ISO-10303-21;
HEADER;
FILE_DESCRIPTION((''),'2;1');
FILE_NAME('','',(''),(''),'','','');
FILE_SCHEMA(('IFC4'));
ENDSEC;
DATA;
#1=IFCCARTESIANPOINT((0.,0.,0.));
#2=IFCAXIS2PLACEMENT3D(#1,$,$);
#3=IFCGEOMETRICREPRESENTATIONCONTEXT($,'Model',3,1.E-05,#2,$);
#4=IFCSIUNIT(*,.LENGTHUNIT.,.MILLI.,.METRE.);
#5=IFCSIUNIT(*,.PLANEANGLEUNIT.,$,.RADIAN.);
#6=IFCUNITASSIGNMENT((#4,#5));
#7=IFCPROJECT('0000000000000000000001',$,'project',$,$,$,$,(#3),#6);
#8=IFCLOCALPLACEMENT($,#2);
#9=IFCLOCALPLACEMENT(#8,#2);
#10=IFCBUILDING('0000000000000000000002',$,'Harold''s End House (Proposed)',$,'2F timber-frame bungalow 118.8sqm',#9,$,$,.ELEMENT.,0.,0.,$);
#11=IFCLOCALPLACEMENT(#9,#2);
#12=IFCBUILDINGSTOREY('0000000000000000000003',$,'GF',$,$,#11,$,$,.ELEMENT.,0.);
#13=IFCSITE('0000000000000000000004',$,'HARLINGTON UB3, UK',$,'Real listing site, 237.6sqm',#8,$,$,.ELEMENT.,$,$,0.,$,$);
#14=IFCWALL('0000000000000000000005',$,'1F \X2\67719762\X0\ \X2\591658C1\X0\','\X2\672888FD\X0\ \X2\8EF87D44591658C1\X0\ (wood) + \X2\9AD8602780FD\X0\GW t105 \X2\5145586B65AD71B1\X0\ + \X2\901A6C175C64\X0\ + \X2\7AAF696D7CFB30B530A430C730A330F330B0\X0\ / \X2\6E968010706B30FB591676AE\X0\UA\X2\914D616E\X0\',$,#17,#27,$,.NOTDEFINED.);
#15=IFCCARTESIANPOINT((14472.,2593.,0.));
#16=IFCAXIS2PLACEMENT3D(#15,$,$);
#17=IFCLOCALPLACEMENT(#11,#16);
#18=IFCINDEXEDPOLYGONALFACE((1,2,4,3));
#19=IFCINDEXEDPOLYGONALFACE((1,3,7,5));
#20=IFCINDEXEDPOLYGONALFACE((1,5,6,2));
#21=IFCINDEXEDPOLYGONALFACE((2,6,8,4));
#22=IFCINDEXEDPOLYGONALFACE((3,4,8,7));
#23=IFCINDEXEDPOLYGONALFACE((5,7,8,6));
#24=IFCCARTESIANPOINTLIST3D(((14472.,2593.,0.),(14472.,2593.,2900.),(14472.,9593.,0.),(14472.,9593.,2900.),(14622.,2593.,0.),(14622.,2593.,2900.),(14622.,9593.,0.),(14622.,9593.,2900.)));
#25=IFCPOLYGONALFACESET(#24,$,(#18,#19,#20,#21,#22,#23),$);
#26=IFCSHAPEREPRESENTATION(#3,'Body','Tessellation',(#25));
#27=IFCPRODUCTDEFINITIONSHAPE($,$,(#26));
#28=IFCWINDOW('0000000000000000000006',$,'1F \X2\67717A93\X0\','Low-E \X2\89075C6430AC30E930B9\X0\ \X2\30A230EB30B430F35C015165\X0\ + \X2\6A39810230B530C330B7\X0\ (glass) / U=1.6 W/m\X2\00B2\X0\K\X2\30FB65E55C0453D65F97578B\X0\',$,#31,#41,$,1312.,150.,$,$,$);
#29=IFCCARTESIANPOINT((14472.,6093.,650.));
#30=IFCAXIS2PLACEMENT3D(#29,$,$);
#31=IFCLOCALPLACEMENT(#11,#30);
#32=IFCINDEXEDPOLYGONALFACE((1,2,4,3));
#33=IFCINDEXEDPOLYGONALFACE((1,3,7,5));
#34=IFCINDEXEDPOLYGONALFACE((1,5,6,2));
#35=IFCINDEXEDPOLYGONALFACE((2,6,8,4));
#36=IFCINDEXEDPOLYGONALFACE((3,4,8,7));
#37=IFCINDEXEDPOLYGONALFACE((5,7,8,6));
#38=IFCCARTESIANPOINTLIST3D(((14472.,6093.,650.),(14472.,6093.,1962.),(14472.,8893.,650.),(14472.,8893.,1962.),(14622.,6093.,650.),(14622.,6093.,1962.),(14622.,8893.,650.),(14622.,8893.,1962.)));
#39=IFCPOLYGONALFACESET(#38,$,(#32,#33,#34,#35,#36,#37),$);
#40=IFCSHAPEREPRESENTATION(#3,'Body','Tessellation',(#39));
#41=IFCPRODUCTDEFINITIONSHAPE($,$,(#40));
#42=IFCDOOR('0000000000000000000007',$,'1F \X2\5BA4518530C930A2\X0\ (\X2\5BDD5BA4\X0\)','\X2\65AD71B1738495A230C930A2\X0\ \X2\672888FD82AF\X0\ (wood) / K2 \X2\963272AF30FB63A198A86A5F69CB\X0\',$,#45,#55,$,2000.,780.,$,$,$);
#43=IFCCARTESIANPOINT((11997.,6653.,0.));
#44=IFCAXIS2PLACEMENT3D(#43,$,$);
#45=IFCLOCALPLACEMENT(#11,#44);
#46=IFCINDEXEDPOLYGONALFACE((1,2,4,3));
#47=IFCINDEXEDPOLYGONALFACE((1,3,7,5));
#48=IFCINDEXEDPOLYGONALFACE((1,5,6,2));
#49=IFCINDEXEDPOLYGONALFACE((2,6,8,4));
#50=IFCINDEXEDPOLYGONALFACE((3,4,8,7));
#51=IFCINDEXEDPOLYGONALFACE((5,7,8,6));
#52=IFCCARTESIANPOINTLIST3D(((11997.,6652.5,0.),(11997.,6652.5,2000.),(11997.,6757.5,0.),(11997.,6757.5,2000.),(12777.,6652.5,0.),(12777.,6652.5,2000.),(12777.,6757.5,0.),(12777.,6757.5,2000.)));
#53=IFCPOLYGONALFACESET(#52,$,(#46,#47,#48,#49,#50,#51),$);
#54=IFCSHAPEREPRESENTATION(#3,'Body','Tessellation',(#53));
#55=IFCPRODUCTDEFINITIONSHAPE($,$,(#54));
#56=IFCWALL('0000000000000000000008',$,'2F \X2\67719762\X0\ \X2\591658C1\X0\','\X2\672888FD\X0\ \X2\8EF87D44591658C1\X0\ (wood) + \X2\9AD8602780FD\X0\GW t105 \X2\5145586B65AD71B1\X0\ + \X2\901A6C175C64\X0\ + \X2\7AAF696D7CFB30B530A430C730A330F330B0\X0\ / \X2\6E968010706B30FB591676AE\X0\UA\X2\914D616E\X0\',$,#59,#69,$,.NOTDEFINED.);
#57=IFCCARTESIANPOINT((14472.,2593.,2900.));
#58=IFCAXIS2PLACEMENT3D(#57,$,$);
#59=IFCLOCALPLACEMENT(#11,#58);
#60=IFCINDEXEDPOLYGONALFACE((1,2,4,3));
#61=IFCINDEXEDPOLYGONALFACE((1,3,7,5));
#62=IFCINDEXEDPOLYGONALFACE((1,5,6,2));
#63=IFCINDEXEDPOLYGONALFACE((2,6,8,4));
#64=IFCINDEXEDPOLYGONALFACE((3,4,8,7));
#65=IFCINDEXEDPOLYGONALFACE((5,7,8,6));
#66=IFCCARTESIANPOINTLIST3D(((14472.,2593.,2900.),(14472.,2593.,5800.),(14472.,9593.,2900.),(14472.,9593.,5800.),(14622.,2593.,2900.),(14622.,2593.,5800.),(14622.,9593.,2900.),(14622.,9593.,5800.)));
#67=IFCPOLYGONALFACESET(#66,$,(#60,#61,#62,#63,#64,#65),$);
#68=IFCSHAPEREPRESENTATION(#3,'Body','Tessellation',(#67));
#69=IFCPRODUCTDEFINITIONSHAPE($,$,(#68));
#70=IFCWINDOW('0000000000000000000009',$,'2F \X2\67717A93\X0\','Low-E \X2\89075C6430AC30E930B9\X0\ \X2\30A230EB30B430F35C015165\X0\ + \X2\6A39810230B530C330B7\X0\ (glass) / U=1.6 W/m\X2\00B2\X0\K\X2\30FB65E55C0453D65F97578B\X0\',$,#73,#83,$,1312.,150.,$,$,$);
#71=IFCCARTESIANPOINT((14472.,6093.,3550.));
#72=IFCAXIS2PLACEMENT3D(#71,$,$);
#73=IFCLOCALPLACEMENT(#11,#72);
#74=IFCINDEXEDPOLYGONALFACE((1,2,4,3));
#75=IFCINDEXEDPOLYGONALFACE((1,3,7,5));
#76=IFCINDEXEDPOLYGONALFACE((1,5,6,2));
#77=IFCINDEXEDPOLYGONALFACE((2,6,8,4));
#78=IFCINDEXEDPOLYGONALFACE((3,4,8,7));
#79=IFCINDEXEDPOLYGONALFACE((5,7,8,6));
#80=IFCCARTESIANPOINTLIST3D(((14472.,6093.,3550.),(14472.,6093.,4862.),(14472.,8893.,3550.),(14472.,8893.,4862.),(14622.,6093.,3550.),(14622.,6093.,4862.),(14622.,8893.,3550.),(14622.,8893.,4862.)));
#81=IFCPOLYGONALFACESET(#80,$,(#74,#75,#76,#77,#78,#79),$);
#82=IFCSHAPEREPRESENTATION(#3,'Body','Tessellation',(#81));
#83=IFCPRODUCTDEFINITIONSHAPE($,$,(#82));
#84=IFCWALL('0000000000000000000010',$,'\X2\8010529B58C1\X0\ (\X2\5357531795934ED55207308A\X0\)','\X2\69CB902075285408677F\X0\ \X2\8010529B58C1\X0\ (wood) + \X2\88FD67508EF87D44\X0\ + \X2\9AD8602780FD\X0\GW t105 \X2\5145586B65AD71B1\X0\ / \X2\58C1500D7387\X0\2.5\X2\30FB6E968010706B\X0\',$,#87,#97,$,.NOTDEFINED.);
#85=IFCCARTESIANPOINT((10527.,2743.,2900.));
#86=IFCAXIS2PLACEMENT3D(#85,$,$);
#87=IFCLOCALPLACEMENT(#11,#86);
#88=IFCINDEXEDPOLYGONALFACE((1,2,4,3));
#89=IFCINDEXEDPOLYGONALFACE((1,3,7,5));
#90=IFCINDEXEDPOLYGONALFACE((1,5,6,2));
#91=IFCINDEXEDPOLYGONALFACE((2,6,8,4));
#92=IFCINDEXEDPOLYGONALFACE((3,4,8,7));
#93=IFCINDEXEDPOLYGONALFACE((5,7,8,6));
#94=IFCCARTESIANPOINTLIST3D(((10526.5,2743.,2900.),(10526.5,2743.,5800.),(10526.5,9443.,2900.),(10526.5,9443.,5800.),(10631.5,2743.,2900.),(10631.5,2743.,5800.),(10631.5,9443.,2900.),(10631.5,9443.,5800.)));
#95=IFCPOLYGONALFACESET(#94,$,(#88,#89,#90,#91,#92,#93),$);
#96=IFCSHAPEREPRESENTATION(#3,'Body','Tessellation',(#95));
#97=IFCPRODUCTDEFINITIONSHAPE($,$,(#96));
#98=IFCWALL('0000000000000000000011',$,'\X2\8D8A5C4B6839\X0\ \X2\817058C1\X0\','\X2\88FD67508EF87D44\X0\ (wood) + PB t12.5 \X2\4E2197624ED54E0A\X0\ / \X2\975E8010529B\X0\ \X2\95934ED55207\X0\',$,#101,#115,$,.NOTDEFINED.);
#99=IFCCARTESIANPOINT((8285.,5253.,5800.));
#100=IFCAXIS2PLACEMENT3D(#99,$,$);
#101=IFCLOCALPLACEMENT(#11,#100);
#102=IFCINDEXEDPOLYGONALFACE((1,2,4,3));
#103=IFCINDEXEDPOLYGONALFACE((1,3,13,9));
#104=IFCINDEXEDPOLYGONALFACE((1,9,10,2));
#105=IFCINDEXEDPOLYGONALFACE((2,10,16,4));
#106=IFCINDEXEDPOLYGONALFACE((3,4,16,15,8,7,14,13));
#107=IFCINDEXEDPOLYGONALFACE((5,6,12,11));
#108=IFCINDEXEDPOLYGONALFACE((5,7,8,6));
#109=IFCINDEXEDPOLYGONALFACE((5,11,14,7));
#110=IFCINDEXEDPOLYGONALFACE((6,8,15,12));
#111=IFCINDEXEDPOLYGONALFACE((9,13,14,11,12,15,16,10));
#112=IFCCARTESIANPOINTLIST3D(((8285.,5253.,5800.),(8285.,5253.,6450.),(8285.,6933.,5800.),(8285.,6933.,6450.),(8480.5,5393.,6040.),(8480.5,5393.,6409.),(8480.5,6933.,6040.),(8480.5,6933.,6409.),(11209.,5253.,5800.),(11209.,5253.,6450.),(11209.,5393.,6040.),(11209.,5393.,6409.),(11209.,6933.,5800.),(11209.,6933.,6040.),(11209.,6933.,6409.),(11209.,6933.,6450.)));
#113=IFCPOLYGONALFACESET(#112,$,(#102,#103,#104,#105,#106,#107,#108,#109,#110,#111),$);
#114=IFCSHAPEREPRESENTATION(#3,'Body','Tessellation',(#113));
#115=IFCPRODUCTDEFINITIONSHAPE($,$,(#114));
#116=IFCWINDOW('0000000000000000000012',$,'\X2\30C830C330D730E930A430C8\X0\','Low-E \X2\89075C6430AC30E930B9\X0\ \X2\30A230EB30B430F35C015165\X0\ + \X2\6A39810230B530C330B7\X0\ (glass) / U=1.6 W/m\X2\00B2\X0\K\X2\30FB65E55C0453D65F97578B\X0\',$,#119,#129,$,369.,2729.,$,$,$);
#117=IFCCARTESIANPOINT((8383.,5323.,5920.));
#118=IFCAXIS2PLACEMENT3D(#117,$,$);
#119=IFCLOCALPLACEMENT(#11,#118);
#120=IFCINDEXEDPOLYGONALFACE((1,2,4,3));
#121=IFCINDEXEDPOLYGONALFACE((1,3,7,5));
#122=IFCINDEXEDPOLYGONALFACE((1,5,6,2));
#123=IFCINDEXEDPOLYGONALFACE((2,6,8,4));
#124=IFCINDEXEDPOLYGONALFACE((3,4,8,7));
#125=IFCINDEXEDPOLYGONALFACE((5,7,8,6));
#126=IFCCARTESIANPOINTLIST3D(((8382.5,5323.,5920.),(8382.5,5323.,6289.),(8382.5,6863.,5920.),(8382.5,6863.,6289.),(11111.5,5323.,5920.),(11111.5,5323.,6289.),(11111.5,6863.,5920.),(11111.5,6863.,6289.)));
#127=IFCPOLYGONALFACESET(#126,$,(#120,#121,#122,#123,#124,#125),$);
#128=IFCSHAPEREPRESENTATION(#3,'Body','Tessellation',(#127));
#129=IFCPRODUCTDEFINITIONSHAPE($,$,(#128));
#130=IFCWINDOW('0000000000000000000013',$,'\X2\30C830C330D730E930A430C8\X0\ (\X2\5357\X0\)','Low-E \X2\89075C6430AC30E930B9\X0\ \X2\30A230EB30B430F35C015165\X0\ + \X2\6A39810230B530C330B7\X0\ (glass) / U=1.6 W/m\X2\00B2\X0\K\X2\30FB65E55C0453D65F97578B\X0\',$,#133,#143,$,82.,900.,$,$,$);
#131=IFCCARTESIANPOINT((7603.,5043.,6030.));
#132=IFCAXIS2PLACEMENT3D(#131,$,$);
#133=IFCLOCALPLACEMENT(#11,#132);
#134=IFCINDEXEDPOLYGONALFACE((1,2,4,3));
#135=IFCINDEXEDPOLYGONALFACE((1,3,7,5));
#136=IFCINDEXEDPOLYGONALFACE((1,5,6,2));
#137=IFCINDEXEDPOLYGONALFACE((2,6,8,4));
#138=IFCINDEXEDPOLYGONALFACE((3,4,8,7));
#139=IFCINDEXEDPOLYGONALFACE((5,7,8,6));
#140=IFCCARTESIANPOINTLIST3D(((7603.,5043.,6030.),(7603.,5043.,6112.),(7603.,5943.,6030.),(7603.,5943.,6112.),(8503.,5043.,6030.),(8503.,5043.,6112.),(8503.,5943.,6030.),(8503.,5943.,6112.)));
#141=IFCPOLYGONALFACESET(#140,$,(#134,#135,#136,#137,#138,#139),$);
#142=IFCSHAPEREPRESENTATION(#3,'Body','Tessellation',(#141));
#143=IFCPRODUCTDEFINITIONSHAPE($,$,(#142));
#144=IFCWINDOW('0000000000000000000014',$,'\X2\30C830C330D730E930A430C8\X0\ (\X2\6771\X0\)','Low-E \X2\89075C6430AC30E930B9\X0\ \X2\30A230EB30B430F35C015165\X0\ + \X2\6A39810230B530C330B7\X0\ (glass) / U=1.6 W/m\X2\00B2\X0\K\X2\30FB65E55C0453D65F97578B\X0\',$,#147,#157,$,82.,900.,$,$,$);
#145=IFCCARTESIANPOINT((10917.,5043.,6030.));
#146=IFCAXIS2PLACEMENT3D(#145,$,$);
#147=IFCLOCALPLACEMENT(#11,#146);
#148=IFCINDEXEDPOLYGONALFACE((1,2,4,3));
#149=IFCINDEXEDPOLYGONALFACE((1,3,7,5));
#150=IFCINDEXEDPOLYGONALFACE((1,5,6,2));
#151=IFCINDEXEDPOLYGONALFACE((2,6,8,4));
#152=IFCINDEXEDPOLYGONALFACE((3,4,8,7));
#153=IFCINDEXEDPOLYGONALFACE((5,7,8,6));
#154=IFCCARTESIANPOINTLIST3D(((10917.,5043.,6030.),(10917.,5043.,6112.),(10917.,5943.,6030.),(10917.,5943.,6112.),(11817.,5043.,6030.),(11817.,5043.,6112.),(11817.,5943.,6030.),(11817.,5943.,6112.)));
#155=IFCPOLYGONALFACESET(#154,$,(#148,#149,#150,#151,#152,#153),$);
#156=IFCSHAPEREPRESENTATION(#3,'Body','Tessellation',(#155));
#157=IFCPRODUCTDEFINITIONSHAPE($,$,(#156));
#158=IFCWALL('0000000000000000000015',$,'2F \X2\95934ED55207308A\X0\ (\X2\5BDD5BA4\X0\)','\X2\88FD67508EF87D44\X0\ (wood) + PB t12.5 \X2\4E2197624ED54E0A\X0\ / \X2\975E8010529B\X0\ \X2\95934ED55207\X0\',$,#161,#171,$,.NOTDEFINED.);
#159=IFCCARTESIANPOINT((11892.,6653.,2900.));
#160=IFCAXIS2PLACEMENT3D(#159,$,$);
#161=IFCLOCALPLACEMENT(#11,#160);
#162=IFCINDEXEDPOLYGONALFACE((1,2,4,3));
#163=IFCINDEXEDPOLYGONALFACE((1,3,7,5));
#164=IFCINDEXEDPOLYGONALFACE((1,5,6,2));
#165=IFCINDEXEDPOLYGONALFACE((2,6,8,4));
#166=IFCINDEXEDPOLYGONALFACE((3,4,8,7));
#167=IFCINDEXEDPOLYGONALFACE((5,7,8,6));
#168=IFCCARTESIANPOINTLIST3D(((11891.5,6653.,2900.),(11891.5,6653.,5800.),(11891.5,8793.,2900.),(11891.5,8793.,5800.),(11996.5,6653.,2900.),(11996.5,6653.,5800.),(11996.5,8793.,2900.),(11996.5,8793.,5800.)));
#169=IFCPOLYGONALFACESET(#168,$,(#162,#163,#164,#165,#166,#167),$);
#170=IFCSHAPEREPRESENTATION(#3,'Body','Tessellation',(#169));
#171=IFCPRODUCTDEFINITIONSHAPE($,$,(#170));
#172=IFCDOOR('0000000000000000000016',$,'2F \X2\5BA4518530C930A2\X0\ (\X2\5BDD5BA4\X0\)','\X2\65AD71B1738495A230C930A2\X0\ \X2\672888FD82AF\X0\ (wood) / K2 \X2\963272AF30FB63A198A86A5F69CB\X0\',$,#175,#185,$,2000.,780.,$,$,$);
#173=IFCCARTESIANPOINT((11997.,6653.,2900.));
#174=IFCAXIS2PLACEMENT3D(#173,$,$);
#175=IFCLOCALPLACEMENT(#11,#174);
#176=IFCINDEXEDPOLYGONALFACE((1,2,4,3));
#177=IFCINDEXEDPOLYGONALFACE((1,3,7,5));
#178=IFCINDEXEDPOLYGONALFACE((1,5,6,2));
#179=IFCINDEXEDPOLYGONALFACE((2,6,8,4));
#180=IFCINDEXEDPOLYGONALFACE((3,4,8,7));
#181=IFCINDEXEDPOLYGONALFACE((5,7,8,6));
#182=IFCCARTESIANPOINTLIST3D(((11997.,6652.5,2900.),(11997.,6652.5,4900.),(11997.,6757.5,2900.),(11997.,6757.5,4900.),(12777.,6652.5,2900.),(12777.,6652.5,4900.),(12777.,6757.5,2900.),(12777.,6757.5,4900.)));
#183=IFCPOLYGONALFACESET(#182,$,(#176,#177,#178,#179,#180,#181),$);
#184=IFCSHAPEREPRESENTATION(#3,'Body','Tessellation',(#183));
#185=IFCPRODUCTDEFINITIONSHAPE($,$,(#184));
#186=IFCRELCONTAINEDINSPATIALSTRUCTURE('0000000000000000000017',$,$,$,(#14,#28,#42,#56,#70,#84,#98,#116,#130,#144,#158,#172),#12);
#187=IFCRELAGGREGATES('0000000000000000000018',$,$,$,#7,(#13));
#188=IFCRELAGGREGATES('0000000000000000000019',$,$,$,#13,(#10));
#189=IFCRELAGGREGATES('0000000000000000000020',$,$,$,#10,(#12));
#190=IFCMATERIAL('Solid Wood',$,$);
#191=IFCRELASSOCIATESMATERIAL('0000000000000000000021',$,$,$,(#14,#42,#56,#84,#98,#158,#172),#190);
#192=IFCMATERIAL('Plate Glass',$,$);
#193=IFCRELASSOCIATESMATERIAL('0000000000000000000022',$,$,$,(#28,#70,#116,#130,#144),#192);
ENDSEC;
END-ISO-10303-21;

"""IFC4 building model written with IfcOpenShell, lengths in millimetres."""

from ifc_helpers import new_model, si_unit, frame, frame_2d, origin, place, context, project, spatial, rectangle, extrude, material, element, fill, save


model = new_model("IFC4")

# Units and contexts
model_context = context("Model", 3, precision=1e-05, world=origin())
ifc_project = project(units=[si_unit("LENGTHUNIT", "METRE", prefix="MILLI"), si_unit("PLANEANGLEUNIT", "RADIAN")], contexts=[model_context])

# Site, building, storey
site_placement = place(None, origin())
site = spatial("IfcSite", under=ifc_project, at=site_placement, Name="HARLINGTON UB3, UK", ObjectType="Real listing site, 237.6sqm", CompositionType="ELEMENT", RefElevation=0.0)
building_placement = place(site_placement, origin())
building = spatial("IfcBuilding", under=site, at=building_placement, Name="Harold's End House (Proposed)", ObjectType="2F timber-frame bungalow 118.8sqm", CompositionType="ELEMENT", ElevationOfRefHeight=0.0, ElevationOfTerrain=0.0)
storey_placement = place(building_placement, origin())
storey = spatial("IfcBuildingStorey", under=building, at=storey_placement, Name="GF", CompositionType="ELEMENT", Elevation=0.0)

# Wall, opening, window
ifc_material_1 = material(Name="Solid Wood")
wall_1_placement = place(storey_placement, frame((14472.0, 2593.0, 0.0)))
wall_1 = element("IfcWall", 1, at=wall_1_placement, inside=storey, material=ifc_material_1, Name="1F 東面 外壁", Description="木製 軸組外壁 (wood) + 高性能GW t105 充填断熱 + 通気層 + 窯業系サイディング / 準耐火・外皮UA配慮", PredefinedType="NOTDEFINED", context=model_context, shape_type="SweptSolid", body=[
    extrude(rectangle(XDim=150.0, YDim=7000.0, at=frame_2d((75.0, 3500.0))), frame((14472.0, 2593.0, 0.0)), (0.0, 0.0, 1.0), 2900.0),
])
opening_1_placement = place(storey_placement, frame((14472.0, 6093.0, 650.0)))
opening_1 = element("IfcOpeningElement", 2, at=opening_1_placement, cuts=wall_1, PredefinedType="NOTDEFINED", context=model_context, shape_type="SweptSolid", body=[
    extrude(rectangle(XDim=150.0, YDim=2800.0, at=frame_2d((75.0, 1400.0))), frame((14472.0, 6093.0, 650.0)), (0.0, 0.0, 1.0), 1312.0),
])
ifc_material_2 = material(Name="Plate Glass")
window_1_placement = place(storey_placement, frame((14472.0, 6093.0, 650.0)))
window_1 = element("IfcWindow", 3, at=window_1_placement, inside=storey, material=ifc_material_2, Name="1F 東窓", Description="Low-E 複層ガラス アルゴン封入 + 樹脂サッシ (glass) / U=1.6 W/m²K・日射取得型", OverallHeight=1312.0, OverallWidth=150.0, context=model_context, shape_type="SweptSolid", body=[
    extrude(rectangle(XDim=150.0, YDim=2800.0, at=frame_2d((75.0, 1400.0))), frame((14472.0, 6093.0, 650.0)), (0.0, 0.0, 1.0), 1312.0),
])
fill(opening_1, window_1)

# Door
door_1_placement = place(storey_placement, frame((11997.0, 6653.0, 0.0)))
element("IfcDoor", 4, at=door_1_placement, inside=storey, material=ifc_material_1, Name="1F 室内ドア (寝室)", Description="断熱玄関ドア 木製芯 (wood) / K2 防犯・採風機構", OverallHeight=2000.0, OverallWidth=780.0, context=model_context, shape_type="SweptSolid", body=[
    extrude(rectangle(XDim=780.0, YDim=105.0, at=frame_2d((390.0, 52.0))), frame((11997.0, 6653.0, 0.0)), (0.0, 0.0, 1.0), 2000.0),
])

# Wall, opening, window
wall_2_placement = place(storey_placement, frame((14472.0, 2593.0, 2900.0)))
wall_2 = element("IfcWall", 5, at=wall_2_placement, inside=storey, material=ifc_material_1, Name="2F 東面 外壁", Description="木製 軸組外壁 (wood) + 高性能GW t105 充填断熱 + 通気層 + 窯業系サイディング / 準耐火・外皮UA配慮", PredefinedType="NOTDEFINED", context=model_context, shape_type="SweptSolid", body=[
    extrude(rectangle(XDim=150.0, YDim=7000.0, at=frame_2d((75.0, 3500.0))), frame((14472.0, 2593.0, 2900.0)), (0.0, 0.0, 1.0), 2900.0),
])
opening_2_placement = place(storey_placement, frame((14472.0, 6093.0, 3550.0)))
opening_2 = element("IfcOpeningElement", 6, at=opening_2_placement, cuts=wall_2, PredefinedType="NOTDEFINED", context=model_context, shape_type="SweptSolid", body=[
    extrude(rectangle(XDim=150.0, YDim=2800.0, at=frame_2d((75.0, 1400.0))), frame((14472.0, 6093.0, 3550.0)), (0.0, 0.0, 1.0), 1312.0),
])
window_2_placement = place(storey_placement, frame((14472.0, 6093.0, 3550.0)))
window_2 = element("IfcWindow", 7, at=window_2_placement, inside=storey, material=ifc_material_2, Name="2F 東窓", Description="Low-E 複層ガラス アルゴン封入 + 樹脂サッシ (glass) / U=1.6 W/m²K・日射取得型", OverallHeight=1312.0, OverallWidth=150.0, context=model_context, shape_type="SweptSolid", body=[
    extrude(rectangle(XDim=150.0, YDim=2800.0, at=frame_2d((75.0, 1400.0))), frame((14472.0, 6093.0, 3550.0)), (0.0, 0.0, 1.0), 1312.0),
])
fill(opening_2, window_2)

# Wall
wall_3_placement = place(storey_placement, frame((10527.0, 2743.0, 2900.0)))
element("IfcWall", 8, at=wall_3_placement, inside=storey, material=ifc_material_1, Name="耐力壁 (南北間仕切り)", Description="構造用合板 耐力壁 (wood) + 製材軸組 + 高性能GW t105 充填断熱 / 壁倍率2.5・準耐火", PredefinedType="NOTDEFINED", context=model_context, shape_type="SweptSolid", body=[
    extrude(rectangle(XDim=105.0, YDim=6700.0, at=frame_2d((52.0, 3350.0))), frame((10527.0, 2743.0, 2900.0)), (0.0, 0.0, 1.0), 2900.0),
])

# Wall, openings, windows
wall_4_placement = place(storey_placement, frame((8285.0, 5253.0, 5800.0)))
wall_4 = element("IfcWall", 9, at=wall_4_placement, inside=storey, material=ifc_material_1, Name="越屋根 腰壁", Description="製材軸組 (wood) + PB t12.5 両面仕上 / 非耐力 間仕切", PredefinedType="NOTDEFINED", context=model_context, shape_type="SweptSolid", body=[
    extrude(rectangle(XDim=2924.0, YDim=1680.0, at=frame_2d((1462.0, 840.0))), frame((8285.0, 5253.0, 5800.0)), (0.0, 0.0, 1.0), 650.0),
])
opening_3_placement = place(storey_placement, frame((8383.0, 5323.0, 5920.0)))
opening_3 = element("IfcOpeningElement", 10, at=opening_3_placement, cuts=wall_4, PredefinedType="NOTDEFINED", context=model_context, shape_type="SweptSolid", body=[
    extrude(rectangle(XDim=2729.0, YDim=1540.0, at=frame_2d((1364.0, 770.0))), frame((8383.0, 5323.0, 5920.0)), (0.0, 0.0, 1.0), 369.0),
])
opening_4_placement = place(storey_placement, frame((7603.0, 5043.0, 6030.0)))
opening_4 = element("IfcOpeningElement", 11, at=opening_4_placement, cuts=wall_4, PredefinedType="NOTDEFINED", context=model_context, shape_type="SweptSolid", body=[
    extrude(rectangle(XDim=900.0, YDim=900.0, at=frame_2d((450.0, 450.0))), frame((7603.0, 5043.0, 6030.0)), (0.0, 0.0, 1.0), 82.0),
])
opening_5_placement = place(storey_placement, frame((10917.0, 5043.0, 6030.0)))
opening_5 = element("IfcOpeningElement", 12, at=opening_5_placement, cuts=wall_4, PredefinedType="NOTDEFINED", context=model_context, shape_type="SweptSolid", body=[
    extrude(rectangle(XDim=900.0, YDim=900.0, at=frame_2d((450.0, 450.0))), frame((10917.0, 5043.0, 6030.0)), (0.0, 0.0, 1.0), 82.0),
])
window_3_placement = place(storey_placement, frame((8383.0, 5323.0, 5920.0)))
window_3 = element("IfcWindow", 13, at=window_3_placement, inside=storey, material=ifc_material_2, Name="トップライト", Description="Low-E 複層ガラス アルゴン封入 + 樹脂サッシ (glass) / U=1.6 W/m²K・日射取得型", OverallHeight=369.0, OverallWidth=2729.0, context=model_context, shape_type="SweptSolid", body=[
    extrude(rectangle(XDim=2729.0, YDim=1540.0, at=frame_2d((1364.0, 770.0))), frame((8383.0, 5323.0, 5920.0)), (0.0, 0.0, 1.0), 369.0),
])
fill(opening_3, window_3)
window_4_placement = place(storey_placement, frame((7603.0, 5043.0, 6030.0)))
window_4 = element("IfcWindow", 14, at=window_4_placement, inside=storey, material=ifc_material_2, Name="トップライト (南)", Description="Low-E 複層ガラス アルゴン封入 + 樹脂サッシ (glass) / U=1.6 W/m²K・日射取得型", OverallHeight=82.0, OverallWidth=900.0, context=model_context, shape_type="SweptSolid", body=[
    extrude(rectangle(XDim=900.0, YDim=900.0, at=frame_2d((450.0, 450.0))), frame((7603.0, 5043.0, 6030.0)), (0.0, 0.0, 1.0), 82.0),
])
fill(opening_4, window_4)
window_5_placement = place(storey_placement, frame((10917.0, 5043.0, 6030.0)))
window_5 = element("IfcWindow", 15, at=window_5_placement, inside=storey, material=ifc_material_2, Name="トップライト (東)", Description="Low-E 複層ガラス アルゴン封入 + 樹脂サッシ (glass) / U=1.6 W/m²K・日射取得型", OverallHeight=82.0, OverallWidth=900.0, context=model_context, shape_type="SweptSolid", body=[
    extrude(rectangle(XDim=900.0, YDim=900.0, at=frame_2d((450.0, 450.0))), frame((10917.0, 5043.0, 6030.0)), (0.0, 0.0, 1.0), 82.0),
])
fill(opening_5, window_5)

# Wall
wall_5_placement = place(storey_placement, frame((11892.0, 6653.0, 2900.0)))
element("IfcWall", 16, at=wall_5_placement, inside=storey, material=ifc_material_1, Name="2F 間仕切り (寝室)", Description="製材軸組 (wood) + PB t12.5 両面仕上 / 非耐力 間仕切", PredefinedType="NOTDEFINED", context=model_context, shape_type="SweptSolid", body=[
    extrude(rectangle(XDim=105.0, YDim=2140.0, at=frame_2d((52.0, 1070.0))), frame((11892.0, 6653.0, 2900.0)), (0.0, 0.0, 1.0), 2900.0),
])

# Door
door_2_placement = place(storey_placement, frame((11997.0, 6653.0, 2900.0)))
element("IfcDoor", 17, at=door_2_placement, inside=storey, material=ifc_material_1, Name="2F 室内ドア (寝室)", Description="断熱玄関ドア 木製芯 (wood) / K2 防犯・採風機構", OverallHeight=2000.0, OverallWidth=780.0, context=model_context, shape_type="SweptSolid", body=[
    extrude(rectangle(XDim=780.0, YDim=105.0, at=frame_2d((390.0, 52.0))), frame((11997.0, 6653.0, 2900.0)), (0.0, 0.0, 1.0), 2000.0),
])

save(model, "model.ifc")
